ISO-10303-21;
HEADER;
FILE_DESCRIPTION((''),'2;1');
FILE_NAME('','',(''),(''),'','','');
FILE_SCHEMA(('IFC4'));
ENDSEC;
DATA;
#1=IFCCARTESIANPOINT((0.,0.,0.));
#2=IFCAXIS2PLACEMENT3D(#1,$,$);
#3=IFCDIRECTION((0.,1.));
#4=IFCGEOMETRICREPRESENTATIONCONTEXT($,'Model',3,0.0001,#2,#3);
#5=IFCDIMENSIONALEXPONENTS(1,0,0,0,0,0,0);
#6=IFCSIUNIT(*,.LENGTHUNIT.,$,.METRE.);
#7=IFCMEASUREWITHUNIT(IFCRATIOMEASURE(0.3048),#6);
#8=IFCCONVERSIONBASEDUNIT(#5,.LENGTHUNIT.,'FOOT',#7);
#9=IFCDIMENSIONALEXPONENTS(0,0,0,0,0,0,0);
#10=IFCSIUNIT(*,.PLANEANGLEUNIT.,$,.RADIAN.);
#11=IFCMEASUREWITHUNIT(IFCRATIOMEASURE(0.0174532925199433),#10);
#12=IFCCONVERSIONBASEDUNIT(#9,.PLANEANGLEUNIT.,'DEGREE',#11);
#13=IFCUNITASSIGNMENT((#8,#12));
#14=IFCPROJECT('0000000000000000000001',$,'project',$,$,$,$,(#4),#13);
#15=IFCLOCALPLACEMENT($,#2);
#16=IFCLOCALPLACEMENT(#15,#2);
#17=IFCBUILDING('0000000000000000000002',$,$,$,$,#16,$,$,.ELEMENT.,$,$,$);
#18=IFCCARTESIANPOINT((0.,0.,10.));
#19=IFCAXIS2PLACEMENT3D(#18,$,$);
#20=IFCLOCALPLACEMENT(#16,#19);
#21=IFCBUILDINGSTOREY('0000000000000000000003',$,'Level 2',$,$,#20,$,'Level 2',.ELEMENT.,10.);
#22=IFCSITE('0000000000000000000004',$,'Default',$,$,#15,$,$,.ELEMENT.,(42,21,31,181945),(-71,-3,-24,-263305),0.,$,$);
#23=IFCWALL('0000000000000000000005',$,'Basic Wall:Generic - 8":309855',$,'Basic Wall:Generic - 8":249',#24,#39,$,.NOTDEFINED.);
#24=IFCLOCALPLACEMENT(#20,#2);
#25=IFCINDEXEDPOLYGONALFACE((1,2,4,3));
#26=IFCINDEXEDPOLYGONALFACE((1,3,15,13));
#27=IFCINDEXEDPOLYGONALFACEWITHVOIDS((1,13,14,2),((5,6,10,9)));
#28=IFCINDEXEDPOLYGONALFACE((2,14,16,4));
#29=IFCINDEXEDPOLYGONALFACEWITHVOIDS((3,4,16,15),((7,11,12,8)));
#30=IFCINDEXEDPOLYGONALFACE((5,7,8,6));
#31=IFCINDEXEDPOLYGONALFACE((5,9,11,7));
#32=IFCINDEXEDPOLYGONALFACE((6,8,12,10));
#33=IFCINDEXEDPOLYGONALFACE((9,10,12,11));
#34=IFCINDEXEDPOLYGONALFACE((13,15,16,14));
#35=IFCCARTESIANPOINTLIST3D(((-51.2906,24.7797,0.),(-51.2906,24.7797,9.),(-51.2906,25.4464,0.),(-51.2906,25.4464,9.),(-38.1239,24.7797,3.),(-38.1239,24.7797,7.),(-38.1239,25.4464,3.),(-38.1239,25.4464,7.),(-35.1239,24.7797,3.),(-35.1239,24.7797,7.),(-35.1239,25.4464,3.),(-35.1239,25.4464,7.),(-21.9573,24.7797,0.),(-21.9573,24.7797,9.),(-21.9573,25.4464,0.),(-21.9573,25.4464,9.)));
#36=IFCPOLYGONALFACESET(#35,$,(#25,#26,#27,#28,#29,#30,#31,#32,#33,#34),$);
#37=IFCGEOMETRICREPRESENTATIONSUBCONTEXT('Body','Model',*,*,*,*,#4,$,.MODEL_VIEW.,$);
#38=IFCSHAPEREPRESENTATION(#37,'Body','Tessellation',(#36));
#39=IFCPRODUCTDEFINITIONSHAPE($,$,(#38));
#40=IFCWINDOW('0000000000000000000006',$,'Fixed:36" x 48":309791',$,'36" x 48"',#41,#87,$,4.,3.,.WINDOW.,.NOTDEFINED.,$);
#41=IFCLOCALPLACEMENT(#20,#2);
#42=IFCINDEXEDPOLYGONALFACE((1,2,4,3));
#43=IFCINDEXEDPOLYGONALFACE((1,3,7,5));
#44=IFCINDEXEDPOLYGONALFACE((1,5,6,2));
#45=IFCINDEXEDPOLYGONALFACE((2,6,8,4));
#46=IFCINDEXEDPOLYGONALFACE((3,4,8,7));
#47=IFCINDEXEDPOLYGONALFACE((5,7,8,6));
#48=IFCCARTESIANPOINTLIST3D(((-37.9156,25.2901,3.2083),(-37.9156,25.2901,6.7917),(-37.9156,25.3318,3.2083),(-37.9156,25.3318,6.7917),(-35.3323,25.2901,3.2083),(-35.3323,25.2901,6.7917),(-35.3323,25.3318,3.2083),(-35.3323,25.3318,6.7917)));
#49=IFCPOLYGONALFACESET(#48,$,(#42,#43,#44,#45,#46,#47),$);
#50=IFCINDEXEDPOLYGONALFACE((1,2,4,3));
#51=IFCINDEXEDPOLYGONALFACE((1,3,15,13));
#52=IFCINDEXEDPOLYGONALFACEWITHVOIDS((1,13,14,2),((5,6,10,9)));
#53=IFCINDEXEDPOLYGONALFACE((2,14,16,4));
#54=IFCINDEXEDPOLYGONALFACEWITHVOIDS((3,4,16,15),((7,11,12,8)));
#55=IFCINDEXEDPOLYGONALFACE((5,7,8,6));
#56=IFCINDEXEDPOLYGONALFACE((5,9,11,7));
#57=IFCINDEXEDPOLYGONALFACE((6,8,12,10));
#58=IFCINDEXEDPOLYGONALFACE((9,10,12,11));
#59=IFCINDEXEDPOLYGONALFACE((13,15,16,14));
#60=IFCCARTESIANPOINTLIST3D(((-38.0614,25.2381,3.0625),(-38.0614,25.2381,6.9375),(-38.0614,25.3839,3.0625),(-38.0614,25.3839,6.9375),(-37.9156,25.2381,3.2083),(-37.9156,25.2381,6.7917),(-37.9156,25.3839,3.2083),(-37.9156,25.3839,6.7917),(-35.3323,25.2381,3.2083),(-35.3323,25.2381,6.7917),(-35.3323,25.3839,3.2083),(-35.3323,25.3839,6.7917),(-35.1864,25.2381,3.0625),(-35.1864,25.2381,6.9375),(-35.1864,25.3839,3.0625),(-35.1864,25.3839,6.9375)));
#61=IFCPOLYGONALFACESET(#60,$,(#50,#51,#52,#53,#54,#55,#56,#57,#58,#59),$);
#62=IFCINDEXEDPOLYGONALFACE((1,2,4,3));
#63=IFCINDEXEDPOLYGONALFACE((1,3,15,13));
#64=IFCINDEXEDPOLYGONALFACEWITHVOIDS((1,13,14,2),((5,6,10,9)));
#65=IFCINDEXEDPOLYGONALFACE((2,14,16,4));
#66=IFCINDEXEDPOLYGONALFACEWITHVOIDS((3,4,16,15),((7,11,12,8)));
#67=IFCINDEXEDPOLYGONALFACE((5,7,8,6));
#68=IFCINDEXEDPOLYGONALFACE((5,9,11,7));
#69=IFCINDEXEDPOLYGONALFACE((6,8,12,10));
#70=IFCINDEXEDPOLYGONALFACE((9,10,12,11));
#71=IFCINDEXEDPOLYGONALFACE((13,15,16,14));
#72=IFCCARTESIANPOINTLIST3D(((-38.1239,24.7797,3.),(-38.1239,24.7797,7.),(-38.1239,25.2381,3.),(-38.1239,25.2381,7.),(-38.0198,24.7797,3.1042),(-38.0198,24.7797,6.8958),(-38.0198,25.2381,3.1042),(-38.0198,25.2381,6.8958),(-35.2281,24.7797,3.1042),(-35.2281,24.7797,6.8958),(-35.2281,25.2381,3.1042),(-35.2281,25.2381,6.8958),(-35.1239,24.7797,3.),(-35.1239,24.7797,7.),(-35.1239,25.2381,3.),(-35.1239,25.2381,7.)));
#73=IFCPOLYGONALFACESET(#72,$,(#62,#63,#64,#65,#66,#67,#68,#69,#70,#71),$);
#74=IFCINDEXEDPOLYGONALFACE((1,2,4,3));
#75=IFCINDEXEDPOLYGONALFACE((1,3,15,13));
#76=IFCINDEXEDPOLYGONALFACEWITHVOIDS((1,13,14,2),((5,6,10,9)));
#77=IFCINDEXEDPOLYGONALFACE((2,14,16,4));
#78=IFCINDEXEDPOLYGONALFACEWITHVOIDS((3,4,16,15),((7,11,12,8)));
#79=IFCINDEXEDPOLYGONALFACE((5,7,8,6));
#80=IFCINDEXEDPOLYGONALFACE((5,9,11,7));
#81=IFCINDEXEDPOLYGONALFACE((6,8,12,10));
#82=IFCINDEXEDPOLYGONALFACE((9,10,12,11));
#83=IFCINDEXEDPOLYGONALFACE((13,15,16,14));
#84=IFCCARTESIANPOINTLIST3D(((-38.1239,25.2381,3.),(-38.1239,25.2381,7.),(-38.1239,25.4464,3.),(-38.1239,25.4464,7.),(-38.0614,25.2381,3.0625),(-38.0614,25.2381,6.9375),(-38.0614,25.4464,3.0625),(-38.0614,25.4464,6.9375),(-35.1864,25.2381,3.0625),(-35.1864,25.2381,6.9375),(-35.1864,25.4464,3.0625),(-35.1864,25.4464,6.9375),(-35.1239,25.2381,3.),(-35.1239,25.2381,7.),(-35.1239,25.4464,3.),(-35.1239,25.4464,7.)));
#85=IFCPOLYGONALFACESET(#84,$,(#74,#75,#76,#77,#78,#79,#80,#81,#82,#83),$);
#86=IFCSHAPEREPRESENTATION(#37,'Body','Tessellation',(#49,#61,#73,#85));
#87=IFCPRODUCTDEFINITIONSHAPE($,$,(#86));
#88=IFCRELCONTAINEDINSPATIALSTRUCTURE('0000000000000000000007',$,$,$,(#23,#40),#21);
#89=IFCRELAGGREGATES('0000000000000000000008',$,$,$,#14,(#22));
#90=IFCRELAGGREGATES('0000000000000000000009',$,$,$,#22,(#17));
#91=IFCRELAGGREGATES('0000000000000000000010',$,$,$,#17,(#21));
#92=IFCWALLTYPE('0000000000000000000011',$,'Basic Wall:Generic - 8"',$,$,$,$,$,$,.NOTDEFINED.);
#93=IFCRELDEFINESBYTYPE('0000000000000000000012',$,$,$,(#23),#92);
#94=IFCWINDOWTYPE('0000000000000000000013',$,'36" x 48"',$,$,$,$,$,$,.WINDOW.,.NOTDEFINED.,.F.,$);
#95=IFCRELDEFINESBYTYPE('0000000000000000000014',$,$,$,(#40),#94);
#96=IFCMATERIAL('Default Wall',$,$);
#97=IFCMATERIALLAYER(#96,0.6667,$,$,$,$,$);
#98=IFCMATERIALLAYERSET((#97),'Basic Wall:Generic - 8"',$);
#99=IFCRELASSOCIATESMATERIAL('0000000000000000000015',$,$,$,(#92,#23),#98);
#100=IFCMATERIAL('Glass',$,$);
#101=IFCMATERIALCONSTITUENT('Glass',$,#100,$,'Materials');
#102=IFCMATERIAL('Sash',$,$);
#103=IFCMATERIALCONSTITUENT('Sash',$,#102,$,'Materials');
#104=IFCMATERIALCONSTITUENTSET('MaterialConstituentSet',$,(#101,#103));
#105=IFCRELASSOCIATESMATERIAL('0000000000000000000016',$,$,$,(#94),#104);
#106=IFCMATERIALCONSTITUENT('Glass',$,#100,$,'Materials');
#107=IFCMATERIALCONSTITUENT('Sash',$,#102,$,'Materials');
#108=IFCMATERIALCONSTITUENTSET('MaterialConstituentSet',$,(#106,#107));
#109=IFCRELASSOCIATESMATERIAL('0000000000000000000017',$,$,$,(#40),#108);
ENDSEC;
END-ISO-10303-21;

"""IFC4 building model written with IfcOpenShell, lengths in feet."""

from ifc_helpers import new_model, entity, si_unit, converted_unit, direction, frame, frame_2d, origin, place, context, subcontext, project, spatial, polyline, rectangle, outline, extrude, clip, bounded_halfspace, source, transform, mapped, material, layer, layer_set, layer_usage, constituent, constituent_set, type_object, type_shapes, element, fill, save


model = new_model("IFC4")

# Units and contexts
model_context = context("Model", 3, precision=0.0001, world=origin(), true_north=direction((0.0, 1.0)))
body_context = subcontext(model_context, "Body", "Model", "MODEL_VIEW")
ifc_project = project(units=[converted_unit("LENGTHUNIT", "FOOT", entity("IfcRatioMeasure", 0.3048), si_unit("LENGTHUNIT", "METRE"), dimensions=[1, 0, 0, 0, 0, 0, 0]), converted_unit("PLANEANGLEUNIT", "DEGREE", entity("IfcRatioMeasure", 0.0174532925199433), si_unit("PLANEANGLEUNIT", "RADIAN"), dimensions=[0, 0, 0, 0, 0, 0, 0])], contexts=[model_context])

# Site, building, storey
site_placement = place(None, origin())
site = spatial("IfcSite", under=ifc_project, at=site_placement, Name="Default", CompositionType="ELEMENT", RefLatitude=(42, 21, 31, 181945), RefLongitude=(-71, -3, -24, -263305), RefElevation=0.0)
building_placement = place(site_placement, origin())
building = spatial("IfcBuilding", under=site, at=building_placement, CompositionType="ELEMENT")
storey_placement = place(building_placement, frame((0.0, 0.0, 10.0)))
storey = spatial("IfcBuildingStorey", under=building, at=storey_placement, Name="Level 2", LongName="Level 2", CompositionType="ELEMENT", Elevation=10.0)

# Shared definitions
ifc_material_1 = material(Name="Default Wall")
ifc_layer_1 = layer(ifc_material_1, 0.6667)
ifc_layer_set_1 = layer_set([ifc_layer_1], Name="Basic Wall:Generic - 8\"")
wall_type = type_object("IfcWallType", Name="Basic Wall:Generic - 8\"", PredefinedType="NOTDEFINED", material=ifc_layer_set_1)

# Wall, opening, window
ifc_material_2 = material(Name="Glass")
ifc_material_3 = material(Name="Sash")
ifc_constituent_1 = constituent(ifc_material_2, Name="Glass", Category="Materials")
ifc_constituent_2 = constituent(ifc_material_3, Name="Sash", Category="Materials")
ifc_constituent_set_1 = constituent_set(constituents=[ifc_constituent_1, ifc_constituent_2], Name="MaterialConstituentSet")
window_type_1 = type_object("IfcWindowType", Name="36\" x 48\"", ParameterTakesPrecedence=False, PartitioningType="NOTDEFINED", PredefinedType="WINDOW", material=ifc_constituent_set_1)
shared_shape_1 = source(origin(), body_context, "Body", "SweptSolid", [
    extrude(rectangle(XDim=0.0417, YDim=2.5833, at=frame_2d((0.0, 0.0), x_axis=(1.0, 0.0))), frame((1.5, 0.5312, 0.2083), z_axis=(0.0, 0.0, 1.0), x_axis=(0.0, 1.0, 0.0)), (0.0, 0.0, 1.0), 3.5833),
    extrude(outline(polyline([(-1.4375, -1.9375), (1.4375, -1.9375), (1.4375, 1.9375), (-1.4375, 1.9375), (-1.4375, -1.9375)]), holes=[polyline([(-1.2917, -1.7917), (-1.2917, 1.7917), (1.2917, 1.7917), (1.2917, -1.7917), (-1.2917, -1.7917)])]), frame((1.5, 0.4583, 2.0), z_axis=(0.0, 1.0, 0.0), x_axis=(1.0, 0.0, 0.0)), (0.0, 0.0, 1.0), 0.1458),
    extrude(outline(polyline([(-1.5, -2.0), (1.5, -2.0), (1.5, 2.0), (-1.5, 2.0), (-1.5, -2.0)]), holes=[polyline([(-1.3958, -1.8958), (-1.3958, 1.8958), (1.3958, 1.8958), (1.3958, -1.8958), (-1.3958, -1.8958)])]), frame((1.5, 0.0, 2.0), z_axis=(0.0, 1.0, 0.0), x_axis=(1.0, 0.0, 0.0)), (0.0, 0.0, 1.0), 0.4583),
    extrude(outline(polyline([(-2.0, -1.5), (2.0, -1.5), (2.0, 1.5), (-2.0, 1.5), (-2.0, -1.5)]), holes=[polyline([(-1.9375, -1.4375), (-1.9375, 1.4375), (1.9375, 1.4375), (1.9375, -1.4375), (-1.9375, -1.4375)])]), frame((1.5, 0.4583, 2.0), z_axis=(0.0, 1.0, 0.0), x_axis=(0.0, 0.0, -1.0)), (0.0, 0.0, 1.0), 0.2083),
])
type_shapes(window_type_1, [shared_shape_1])
ifc_layer_usage_1 = layer_usage(ifc_layer_set_1, "AXIS2", "NEGATIVE", 0.3333)
wall_1_placement = place(storey_placement, frame((-51.2906, 25.1131, 0.0)))
wall_1 = element("IfcWall", 1, at=wall_1_placement, inside=storey, type_object=wall_type, material=ifc_layer_usage_1, Name="Basic Wall:Generic - 8\":309855", ObjectType="Basic Wall:Generic - 8\":249", PredefinedType="NOTDEFINED", context=body_context, shape_type="Clipping", body=[
    clip(extrude(rectangle(XDim=29.3333, YDim=0.6667, at=frame_2d((14.6667, 0.0), x_axis=(-1.0, 0.0))), origin(), (0.0, 0.0, 1.0), 9.0), bounded_halfspace(frame((0.0, -0.3333, 9.0), z_axis=(0.0, 0.0, -1.0), x_axis=(1.0, 0.0, 0.0)), True, frame((0.0, -0.3333, 9.0)), polyline([(0.0, 0.0), (29.3333, 0.0), (29.3333, 0.6667), (0.0, 0.6667), (0.0, 0.0)]))),
])
opening_1_placement = place(wall_1_placement, frame((13.1667, -0.3333, 3.0)))
opening_1 = element("IfcOpeningElement", 2, at=opening_1_placement, cuts=wall_1, ObjectType="Opening", PredefinedType="OPENING", context=body_context, shape_type="SweptSolid", body=[
    extrude(rectangle(XDim=4.0, YDim=3.0, at=frame_2d((2.0, 1.5), x_axis=(-1.0, 0.0))), frame((0.0, 0.0, 0.0), z_axis=(0.0, 1.0, 0.0), x_axis=(0.0, 0.0, 1.0)), (0.0, 0.0, 1.0), 0.6667),
])
ifc_constituent_3 = constituent(ifc_material_2, Name="Glass", Category="Materials")
ifc_constituent_4 = constituent(ifc_material_3, Name="Sash", Category="Materials")
ifc_constituent_set_2 = constituent_set(constituents=[ifc_constituent_3, ifc_constituent_4], Name="MaterialConstituentSet")
window_1_placement = place(opening_1_placement, origin())
window_1 = element("IfcWindow", 3, at=window_1_placement, inside=storey, type_object=window_type_1, material=ifc_constituent_set_2, Name="Fixed:36\" x 48\":309791", ObjectType="36\" x 48\"", OverallHeight=4.0, OverallWidth=3.0, PartitioningType="NOTDEFINED", PredefinedType="WINDOW", context=body_context, shape_type="MappedRepresentation", body=[
    mapped(shared_shape_1, transform((0.0, 0.0, 0.0), scale=1.0)),
])
fill(opening_1, window_1)

save(model, "model.ifc")
